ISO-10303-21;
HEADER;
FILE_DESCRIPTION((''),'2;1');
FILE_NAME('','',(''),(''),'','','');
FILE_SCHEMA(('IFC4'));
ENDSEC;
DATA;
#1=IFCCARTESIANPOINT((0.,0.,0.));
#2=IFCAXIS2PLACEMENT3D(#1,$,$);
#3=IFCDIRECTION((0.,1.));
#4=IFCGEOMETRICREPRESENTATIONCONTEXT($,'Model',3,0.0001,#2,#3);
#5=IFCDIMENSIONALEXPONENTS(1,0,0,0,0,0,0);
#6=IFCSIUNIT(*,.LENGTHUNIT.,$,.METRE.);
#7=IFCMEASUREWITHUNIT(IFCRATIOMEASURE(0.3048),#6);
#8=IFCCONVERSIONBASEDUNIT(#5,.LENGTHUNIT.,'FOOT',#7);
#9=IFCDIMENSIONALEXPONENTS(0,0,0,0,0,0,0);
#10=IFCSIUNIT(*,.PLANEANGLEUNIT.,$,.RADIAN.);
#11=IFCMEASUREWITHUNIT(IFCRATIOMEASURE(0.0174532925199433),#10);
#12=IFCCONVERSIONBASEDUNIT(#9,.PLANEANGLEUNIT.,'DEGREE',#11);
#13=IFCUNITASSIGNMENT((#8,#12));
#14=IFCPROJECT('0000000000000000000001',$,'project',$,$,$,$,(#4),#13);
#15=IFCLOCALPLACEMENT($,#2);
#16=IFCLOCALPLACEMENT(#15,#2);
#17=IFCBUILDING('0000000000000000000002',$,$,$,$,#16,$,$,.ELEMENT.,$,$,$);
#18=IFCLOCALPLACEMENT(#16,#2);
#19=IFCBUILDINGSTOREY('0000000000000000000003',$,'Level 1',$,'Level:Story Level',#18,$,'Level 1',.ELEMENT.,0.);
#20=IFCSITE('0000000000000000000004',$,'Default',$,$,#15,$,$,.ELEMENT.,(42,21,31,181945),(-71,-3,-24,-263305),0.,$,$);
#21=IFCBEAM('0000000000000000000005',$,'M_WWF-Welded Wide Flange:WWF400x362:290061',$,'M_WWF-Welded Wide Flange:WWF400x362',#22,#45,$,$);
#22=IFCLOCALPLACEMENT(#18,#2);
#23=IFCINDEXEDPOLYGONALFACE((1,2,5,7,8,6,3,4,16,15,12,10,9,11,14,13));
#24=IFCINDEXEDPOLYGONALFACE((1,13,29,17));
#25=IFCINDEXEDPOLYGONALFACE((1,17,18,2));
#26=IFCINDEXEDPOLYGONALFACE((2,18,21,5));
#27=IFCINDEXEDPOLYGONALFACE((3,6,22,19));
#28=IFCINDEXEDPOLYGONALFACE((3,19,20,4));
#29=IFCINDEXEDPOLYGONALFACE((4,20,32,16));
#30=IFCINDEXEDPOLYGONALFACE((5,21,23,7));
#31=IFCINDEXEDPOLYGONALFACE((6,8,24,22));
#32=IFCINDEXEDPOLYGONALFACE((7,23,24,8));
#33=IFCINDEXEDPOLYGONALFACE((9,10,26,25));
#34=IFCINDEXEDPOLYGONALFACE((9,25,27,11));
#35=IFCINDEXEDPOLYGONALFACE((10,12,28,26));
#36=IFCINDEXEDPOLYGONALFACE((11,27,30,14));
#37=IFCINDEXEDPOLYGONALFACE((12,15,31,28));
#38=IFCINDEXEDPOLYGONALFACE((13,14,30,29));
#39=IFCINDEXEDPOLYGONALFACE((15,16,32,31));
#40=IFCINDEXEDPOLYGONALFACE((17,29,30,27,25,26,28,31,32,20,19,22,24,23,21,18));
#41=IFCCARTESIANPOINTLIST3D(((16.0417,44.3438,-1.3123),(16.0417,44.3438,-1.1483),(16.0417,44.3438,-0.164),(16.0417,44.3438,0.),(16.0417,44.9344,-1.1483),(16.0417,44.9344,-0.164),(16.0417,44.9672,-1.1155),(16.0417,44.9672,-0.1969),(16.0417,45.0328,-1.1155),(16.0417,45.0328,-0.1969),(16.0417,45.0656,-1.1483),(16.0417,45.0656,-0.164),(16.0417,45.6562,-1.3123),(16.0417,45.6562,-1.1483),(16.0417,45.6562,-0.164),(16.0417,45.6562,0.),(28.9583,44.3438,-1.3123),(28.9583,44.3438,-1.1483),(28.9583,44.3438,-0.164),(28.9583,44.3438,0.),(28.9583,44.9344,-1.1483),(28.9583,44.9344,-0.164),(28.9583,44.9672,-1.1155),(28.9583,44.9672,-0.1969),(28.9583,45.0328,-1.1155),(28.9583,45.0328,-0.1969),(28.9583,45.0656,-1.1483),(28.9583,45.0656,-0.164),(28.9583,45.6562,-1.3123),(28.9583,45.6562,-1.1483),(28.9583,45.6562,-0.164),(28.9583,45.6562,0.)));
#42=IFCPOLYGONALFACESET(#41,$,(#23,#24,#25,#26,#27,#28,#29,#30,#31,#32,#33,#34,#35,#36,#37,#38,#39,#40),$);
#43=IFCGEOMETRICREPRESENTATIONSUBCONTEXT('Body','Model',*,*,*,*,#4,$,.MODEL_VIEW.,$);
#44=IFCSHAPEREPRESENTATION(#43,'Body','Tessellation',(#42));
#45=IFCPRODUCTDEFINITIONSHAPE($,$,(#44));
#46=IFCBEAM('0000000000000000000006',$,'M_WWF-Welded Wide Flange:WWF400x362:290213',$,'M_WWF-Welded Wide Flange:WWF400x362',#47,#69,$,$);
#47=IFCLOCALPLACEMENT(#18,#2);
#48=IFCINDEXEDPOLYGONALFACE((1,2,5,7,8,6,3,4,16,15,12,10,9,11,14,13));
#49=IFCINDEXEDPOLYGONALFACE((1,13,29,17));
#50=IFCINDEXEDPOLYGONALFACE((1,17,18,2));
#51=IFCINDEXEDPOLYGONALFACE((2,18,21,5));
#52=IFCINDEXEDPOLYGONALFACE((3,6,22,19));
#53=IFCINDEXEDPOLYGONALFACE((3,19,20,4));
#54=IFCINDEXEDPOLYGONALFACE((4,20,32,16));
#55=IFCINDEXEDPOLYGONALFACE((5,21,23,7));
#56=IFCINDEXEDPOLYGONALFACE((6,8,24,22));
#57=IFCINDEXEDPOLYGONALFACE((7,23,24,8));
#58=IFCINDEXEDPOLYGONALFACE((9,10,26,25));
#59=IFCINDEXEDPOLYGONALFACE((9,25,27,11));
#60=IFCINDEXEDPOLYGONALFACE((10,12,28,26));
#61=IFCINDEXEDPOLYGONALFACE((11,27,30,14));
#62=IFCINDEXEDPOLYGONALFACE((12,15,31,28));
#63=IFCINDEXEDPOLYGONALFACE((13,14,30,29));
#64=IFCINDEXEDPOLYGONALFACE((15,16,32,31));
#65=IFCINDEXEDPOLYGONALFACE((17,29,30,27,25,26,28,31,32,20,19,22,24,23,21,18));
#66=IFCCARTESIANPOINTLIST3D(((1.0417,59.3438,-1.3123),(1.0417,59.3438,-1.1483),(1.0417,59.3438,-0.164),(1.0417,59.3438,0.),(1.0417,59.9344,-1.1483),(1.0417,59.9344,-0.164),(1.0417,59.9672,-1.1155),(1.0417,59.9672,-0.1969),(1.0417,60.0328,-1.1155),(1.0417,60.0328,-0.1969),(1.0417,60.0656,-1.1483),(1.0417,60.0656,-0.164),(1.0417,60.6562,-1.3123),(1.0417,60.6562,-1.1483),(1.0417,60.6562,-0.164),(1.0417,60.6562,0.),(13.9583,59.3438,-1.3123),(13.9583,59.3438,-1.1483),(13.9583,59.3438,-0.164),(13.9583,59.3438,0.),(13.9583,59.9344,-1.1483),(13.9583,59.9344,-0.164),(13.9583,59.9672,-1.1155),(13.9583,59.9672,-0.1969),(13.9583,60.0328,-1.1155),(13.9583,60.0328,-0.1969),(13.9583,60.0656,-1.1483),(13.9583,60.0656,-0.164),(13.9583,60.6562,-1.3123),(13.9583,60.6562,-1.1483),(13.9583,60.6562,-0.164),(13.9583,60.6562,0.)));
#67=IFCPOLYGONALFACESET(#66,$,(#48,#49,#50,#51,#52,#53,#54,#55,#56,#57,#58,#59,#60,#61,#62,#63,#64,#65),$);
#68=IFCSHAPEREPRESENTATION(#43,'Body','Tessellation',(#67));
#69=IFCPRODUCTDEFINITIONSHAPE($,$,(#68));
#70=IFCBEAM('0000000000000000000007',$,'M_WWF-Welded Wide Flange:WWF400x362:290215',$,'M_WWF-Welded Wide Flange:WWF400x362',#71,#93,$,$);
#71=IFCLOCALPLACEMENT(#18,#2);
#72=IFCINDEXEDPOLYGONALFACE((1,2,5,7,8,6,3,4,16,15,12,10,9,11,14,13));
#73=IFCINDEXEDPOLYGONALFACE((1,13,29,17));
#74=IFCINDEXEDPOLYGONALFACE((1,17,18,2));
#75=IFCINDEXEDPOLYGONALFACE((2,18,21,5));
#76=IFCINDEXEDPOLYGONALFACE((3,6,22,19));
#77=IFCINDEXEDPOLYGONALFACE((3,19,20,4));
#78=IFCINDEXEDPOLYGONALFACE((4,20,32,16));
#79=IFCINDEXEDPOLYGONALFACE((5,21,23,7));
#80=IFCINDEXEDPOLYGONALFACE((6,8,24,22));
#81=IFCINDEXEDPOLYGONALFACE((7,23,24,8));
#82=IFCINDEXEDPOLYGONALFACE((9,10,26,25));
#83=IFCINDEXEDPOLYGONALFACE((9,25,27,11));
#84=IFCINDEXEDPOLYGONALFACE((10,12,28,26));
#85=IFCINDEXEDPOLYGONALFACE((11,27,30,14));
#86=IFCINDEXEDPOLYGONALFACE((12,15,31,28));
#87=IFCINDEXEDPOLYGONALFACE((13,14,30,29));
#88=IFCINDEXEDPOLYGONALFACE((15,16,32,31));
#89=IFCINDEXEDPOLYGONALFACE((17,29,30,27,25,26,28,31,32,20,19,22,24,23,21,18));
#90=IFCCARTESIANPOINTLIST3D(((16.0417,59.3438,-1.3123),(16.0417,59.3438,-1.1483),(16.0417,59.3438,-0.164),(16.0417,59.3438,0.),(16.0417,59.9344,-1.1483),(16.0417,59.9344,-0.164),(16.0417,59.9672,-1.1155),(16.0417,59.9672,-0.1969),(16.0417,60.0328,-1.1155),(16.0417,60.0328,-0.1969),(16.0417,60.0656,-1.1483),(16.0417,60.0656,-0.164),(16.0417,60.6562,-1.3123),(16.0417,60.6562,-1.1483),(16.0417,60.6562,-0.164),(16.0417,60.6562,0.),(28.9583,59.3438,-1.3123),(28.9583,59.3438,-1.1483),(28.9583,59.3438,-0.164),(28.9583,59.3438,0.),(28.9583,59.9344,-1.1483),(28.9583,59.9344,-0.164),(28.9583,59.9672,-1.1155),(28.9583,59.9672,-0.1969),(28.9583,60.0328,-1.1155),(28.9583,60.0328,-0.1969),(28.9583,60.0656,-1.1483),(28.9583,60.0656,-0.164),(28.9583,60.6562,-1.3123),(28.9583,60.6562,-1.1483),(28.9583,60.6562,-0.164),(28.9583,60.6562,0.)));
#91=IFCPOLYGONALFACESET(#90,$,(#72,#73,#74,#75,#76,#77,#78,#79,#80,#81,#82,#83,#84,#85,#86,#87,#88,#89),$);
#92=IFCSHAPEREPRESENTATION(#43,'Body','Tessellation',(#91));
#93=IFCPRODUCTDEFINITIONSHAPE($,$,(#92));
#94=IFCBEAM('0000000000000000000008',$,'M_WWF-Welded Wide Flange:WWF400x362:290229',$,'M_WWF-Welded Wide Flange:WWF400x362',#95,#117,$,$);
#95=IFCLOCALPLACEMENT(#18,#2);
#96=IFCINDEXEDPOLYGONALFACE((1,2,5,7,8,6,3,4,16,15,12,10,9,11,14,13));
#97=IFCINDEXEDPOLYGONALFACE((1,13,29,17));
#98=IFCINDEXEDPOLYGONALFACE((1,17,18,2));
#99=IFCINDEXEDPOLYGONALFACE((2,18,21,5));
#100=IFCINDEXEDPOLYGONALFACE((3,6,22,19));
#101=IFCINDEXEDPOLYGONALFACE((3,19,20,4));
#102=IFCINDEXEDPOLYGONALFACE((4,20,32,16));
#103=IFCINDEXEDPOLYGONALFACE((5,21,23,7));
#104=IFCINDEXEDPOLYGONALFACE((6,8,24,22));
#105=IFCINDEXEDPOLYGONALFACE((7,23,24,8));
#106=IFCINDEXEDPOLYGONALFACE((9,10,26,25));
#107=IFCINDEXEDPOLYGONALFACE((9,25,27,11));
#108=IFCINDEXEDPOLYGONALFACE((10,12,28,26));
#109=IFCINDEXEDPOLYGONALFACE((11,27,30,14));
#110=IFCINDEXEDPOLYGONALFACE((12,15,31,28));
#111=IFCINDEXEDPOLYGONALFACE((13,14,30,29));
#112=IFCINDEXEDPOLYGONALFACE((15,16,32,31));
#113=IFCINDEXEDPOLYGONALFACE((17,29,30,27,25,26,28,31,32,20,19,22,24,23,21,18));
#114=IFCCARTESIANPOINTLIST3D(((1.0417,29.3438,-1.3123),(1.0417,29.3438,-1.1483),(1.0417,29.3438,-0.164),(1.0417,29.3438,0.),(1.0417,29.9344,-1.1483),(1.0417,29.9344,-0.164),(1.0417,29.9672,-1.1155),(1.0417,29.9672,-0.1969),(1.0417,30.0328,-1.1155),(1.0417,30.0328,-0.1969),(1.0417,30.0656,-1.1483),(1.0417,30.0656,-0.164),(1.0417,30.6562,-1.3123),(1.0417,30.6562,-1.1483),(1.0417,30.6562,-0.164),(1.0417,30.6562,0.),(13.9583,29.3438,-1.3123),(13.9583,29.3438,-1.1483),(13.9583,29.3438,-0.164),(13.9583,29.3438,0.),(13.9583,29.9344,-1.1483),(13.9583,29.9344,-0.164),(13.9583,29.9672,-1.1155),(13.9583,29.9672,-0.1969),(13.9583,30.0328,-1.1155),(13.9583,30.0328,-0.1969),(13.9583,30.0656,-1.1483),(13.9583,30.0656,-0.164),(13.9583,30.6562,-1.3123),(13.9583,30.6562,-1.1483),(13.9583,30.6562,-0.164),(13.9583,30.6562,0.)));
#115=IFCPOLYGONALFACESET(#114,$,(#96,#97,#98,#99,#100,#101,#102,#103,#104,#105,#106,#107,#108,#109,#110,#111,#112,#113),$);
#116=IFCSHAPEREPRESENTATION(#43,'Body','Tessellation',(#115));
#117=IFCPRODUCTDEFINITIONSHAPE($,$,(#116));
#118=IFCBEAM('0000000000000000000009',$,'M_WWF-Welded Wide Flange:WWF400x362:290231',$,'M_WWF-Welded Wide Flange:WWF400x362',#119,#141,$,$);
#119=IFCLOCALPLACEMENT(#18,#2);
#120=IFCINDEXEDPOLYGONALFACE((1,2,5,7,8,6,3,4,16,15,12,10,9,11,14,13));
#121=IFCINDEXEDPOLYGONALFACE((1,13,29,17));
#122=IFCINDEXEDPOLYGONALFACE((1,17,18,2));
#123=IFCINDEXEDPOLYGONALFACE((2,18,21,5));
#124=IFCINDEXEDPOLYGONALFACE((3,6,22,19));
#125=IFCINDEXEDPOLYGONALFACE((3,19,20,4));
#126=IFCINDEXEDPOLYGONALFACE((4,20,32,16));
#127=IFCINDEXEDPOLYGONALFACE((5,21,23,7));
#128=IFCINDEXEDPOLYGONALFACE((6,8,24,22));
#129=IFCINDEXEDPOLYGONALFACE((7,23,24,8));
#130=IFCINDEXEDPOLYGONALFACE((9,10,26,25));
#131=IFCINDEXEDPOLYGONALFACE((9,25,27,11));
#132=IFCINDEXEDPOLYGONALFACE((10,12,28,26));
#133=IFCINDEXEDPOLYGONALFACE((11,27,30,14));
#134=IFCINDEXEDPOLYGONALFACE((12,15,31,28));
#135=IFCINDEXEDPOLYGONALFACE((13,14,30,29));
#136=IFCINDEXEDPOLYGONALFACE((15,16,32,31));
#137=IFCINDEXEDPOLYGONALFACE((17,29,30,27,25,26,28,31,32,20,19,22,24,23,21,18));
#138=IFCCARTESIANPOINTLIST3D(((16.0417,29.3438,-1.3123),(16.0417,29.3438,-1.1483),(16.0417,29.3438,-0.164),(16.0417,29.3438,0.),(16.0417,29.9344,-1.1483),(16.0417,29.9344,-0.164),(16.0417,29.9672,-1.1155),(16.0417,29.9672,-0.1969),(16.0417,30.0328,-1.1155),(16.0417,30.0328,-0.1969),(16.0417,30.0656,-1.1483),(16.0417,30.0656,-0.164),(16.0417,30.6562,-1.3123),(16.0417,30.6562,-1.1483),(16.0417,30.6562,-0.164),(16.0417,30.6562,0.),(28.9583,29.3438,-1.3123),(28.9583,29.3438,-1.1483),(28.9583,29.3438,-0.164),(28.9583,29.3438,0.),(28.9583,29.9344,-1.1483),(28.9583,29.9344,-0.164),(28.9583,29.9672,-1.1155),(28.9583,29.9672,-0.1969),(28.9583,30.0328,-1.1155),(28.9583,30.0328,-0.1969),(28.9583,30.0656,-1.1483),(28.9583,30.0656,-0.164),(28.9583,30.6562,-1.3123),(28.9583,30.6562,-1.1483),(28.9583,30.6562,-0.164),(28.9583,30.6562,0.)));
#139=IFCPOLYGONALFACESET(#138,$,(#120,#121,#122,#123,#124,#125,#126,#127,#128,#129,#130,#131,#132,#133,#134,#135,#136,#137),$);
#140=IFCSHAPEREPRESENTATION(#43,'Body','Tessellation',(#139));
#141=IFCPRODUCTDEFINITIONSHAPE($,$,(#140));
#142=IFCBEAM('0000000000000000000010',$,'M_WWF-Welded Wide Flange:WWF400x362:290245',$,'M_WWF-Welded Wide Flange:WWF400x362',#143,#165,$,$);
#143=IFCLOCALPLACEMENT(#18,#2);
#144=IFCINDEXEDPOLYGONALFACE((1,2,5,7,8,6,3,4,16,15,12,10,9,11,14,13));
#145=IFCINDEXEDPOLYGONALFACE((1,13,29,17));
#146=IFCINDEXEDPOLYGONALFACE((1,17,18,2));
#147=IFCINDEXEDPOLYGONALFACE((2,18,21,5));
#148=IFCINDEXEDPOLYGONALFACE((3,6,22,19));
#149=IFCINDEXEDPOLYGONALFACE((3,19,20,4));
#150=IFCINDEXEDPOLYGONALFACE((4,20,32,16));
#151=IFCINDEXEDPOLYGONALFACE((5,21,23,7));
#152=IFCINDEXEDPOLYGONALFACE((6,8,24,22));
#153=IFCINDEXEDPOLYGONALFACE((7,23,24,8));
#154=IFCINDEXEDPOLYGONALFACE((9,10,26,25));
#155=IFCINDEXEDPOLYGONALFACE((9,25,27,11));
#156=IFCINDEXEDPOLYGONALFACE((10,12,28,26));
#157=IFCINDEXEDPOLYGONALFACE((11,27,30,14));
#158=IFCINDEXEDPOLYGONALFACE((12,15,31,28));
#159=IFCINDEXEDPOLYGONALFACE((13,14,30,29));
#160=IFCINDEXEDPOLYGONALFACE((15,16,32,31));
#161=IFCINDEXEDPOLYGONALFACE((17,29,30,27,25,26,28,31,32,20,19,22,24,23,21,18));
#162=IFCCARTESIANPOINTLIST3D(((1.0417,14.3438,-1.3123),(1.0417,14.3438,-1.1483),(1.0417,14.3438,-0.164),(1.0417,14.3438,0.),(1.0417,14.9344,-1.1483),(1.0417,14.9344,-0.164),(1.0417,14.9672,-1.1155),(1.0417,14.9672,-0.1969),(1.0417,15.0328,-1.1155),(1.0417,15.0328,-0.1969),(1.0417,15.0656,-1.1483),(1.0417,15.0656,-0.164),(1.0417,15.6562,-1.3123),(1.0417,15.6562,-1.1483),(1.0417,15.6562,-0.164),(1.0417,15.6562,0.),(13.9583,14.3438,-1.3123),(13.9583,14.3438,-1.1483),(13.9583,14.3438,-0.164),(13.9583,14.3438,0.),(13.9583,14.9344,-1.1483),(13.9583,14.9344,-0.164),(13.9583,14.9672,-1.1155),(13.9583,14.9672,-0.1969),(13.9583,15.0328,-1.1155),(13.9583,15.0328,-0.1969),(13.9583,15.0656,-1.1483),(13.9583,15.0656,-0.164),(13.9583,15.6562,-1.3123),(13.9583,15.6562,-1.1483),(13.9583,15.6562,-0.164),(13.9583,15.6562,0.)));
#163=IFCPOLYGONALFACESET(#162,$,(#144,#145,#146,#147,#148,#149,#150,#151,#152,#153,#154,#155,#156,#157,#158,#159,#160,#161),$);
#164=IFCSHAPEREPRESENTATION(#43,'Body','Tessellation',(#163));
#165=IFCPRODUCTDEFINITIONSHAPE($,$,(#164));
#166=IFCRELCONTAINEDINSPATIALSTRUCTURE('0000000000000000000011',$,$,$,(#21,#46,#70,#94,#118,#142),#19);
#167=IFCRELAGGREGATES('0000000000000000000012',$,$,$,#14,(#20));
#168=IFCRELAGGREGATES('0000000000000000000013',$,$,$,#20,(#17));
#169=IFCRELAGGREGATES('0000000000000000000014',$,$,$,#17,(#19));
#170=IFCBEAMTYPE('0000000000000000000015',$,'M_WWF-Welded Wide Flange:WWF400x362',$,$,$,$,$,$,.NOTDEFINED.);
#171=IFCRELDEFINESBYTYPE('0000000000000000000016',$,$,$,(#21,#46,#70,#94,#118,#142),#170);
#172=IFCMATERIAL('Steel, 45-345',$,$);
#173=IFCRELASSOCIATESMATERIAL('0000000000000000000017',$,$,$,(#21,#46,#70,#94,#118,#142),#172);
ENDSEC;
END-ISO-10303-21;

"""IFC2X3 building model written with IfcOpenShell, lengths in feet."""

from ifc_helpers import new_model, entity, si_unit, converted_unit, direction, frame, origin, place, context, subcontext, project, spatial, polyline, outline, extrude, material, type_object, element, save


model = new_model("IFC2X3")

# Units and contexts
model_context = context("Model", 3, precision=0.0001, world=origin(), true_north=direction((0.0, 1.0)))
body_context = subcontext(model_context, "Body", "Model", "MODEL_VIEW")
ifc_project = project(units=[converted_unit("LENGTHUNIT", "FOOT", entity("IfcRatioMeasure", 0.3048), si_unit("LENGTHUNIT", "METRE"), dimensions=[1, 0, 0, 0, 0, 0, 0]), converted_unit("PLANEANGLEUNIT", "DEGREE", entity("IfcRatioMeasure", 0.0174532925199433), si_unit("PLANEANGLEUNIT", "RADIAN"), dimensions=[0, 0, 0, 0, 0, 0, 0])], contexts=[model_context])

# Site, building, storey
site_placement = place(None, origin())
site = spatial("IfcSite", under=ifc_project, at=site_placement, Name="Default", CompositionType="ELEMENT", RefLatitude=(42, 21, 31, 181945), RefLongitude=(-71, -3, -24, -263305), RefElevation=0.0)
building_placement = place(site_placement, origin())
building = spatial("IfcBuilding", under=site, at=building_placement, CompositionType="ELEMENT")
storey_placement = place(building_placement, origin())
storey = spatial("IfcBuildingStorey", under=building, at=storey_placement, Name="Level 1", ObjectType="Level:Story Level", LongName="Level 1", CompositionType="ELEMENT", Elevation=0.0)

# Shared definitions
ifc_material = material(Name="Steel, 45-345")

# Beams
beam_type = type_object("IfcBeamType", Name="M_WWF-Welded Wide Flange:WWF400x362", PredefinedType="NOTDEFINED")
beam_1_placement = place(storey_placement, frame((15.0, 45.0, 0.0)))
element("IfcBeam", 1, at=beam_1_placement, inside=storey, type_object=beam_type, material=ifc_material, Name="M_WWF-Welded Wide Flange:WWF400x362:290061", ObjectType="M_WWF-Welded Wide Flange:WWF400x362", context=body_context, shape_type="SweptSolid", body=[
    extrude(outline(polyline([(-0.6562, -0.6562), (-0.4921, -0.6562), (-0.4921, -0.0656), (-0.4593, -0.0328), (0.4593, -0.0328), (0.4921, -0.0656), (0.4921, -0.6562), (0.6562, -0.6562), (0.6562, 0.6562), (0.4921, 0.6562), (0.4921, 0.0656), (0.4593, 0.0328), (-0.4593, 0.0328), (-0.4921, 0.0656), (-0.4921, 0.6562), (-0.6562, 0.6562), (-0.6562, -0.6562)])), frame((1.0417, 0.0, -0.6562), z_axis=(1.0, 0.0, 0.0), x_axis=(0.0, 0.0, -1.0)), (0.0, 0.0, 1.0), 12.9167),
])
beam_2_placement = place(storey_placement, frame((0.0, 60.0, 0.0)))
element("IfcBeam", 2, at=beam_2_placement, inside=storey, type_object=beam_type, material=ifc_material, Name="M_WWF-Welded Wide Flange:WWF400x362:290213", ObjectType="M_WWF-Welded Wide Flange:WWF400x362", context=body_context, shape_type="SweptSolid", body=[
    extrude(outline(polyline([(-0.6562, -0.6562), (-0.4921, -0.6562), (-0.4921, -0.0656), (-0.4593, -0.0328), (0.4593, -0.0328), (0.4921, -0.0656), (0.4921, -0.6562), (0.6562, -0.6562), (0.6562, 0.6562), (0.4921, 0.6562), (0.4921, 0.0656), (0.4593, 0.0328), (-0.4593, 0.0328), (-0.4921, 0.0656), (-0.4921, 0.6562), (-0.6562, 0.6562), (-0.6562, -0.6562)])), frame((1.0417, 0.0, -0.6562), z_axis=(1.0, 0.0, 0.0), x_axis=(0.0, 0.0, -1.0)), (0.0, 0.0, 1.0), 12.9167),
])
beam_3_placement = place(storey_placement, frame((15.0, 60.0, 0.0)))
element("IfcBeam", 3, at=beam_3_placement, inside=storey, type_object=beam_type, material=ifc_material, Name="M_WWF-Welded Wide Flange:WWF400x362:290215", ObjectType="M_WWF-Welded Wide Flange:WWF400x362", context=body_context, shape_type="SweptSolid", body=[
    extrude(outline(polyline([(-0.6562, -0.6562), (-0.4921, -0.6562), (-0.4921, -0.0656), (-0.4593, -0.0328), (0.4593, -0.0328), (0.4921, -0.0656), (0.4921, -0.6562), (0.6562, -0.6562), (0.6562, 0.6562), (0.4921, 0.6562), (0.4921, 0.0656), (0.4593, 0.0328), (-0.4593, 0.0328), (-0.4921, 0.0656), (-0.4921, 0.6562), (-0.6562, 0.6562), (-0.6562, -0.6562)])), frame((1.0417, 0.0, -0.6562), z_axis=(1.0, 0.0, 0.0), x_axis=(0.0, 0.0, -1.0)), (0.0, 0.0, 1.0), 12.9167),
])
beam_4_placement = place(storey_placement, frame((0.0, 30.0, 0.0)))
element("IfcBeam", 4, at=beam_4_placement, inside=storey, type_object=beam_type, material=ifc_material, Name="M_WWF-Welded Wide Flange:WWF400x362:290229", ObjectType="M_WWF-Welded Wide Flange:WWF400x362", context=body_context, shape_type="SweptSolid", body=[
    extrude(outline(polyline([(-0.6562, -0.6562), (-0.4921, -0.6562), (-0.4921, -0.0656), (-0.4593, -0.0328), (0.4593, -0.0328), (0.4921, -0.0656), (0.4921, -0.6562), (0.6562, -0.6562), (0.6562, 0.6562), (0.4921, 0.6562), (0.4921, 0.0656), (0.4593, 0.0328), (-0.4593, 0.0328), (-0.4921, 0.0656), (-0.4921, 0.6562), (-0.6562, 0.6562), (-0.6562, -0.6562)])), frame((1.0417, 0.0, -0.6562), z_axis=(1.0, 0.0, 0.0), x_axis=(0.0, 0.0, -1.0)), (0.0, 0.0, 1.0), 12.9167),
])
beam_5_placement = place(storey_placement, frame((15.0, 30.0, 0.0)))
element("IfcBeam", 5, at=beam_5_placement, inside=storey, type_object=beam_type, material=ifc_material, Name="M_WWF-Welded Wide Flange:WWF400x362:290231", ObjectType="M_WWF-Welded Wide Flange:WWF400x362", context=body_context, shape_type="SweptSolid", body=[
    extrude(outline(polyline([(-0.6562, -0.6562), (-0.4921, -0.6562), (-0.4921, -0.0656), (-0.4593, -0.0328), (0.4593, -0.0328), (0.4921, -0.0656), (0.4921, -0.6562), (0.6562, -0.6562), (0.6562, 0.6562), (0.4921, 0.6562), (0.4921, 0.0656), (0.4593, 0.0328), (-0.4593, 0.0328), (-0.4921, 0.0656), (-0.4921, 0.6562), (-0.6562, 0.6562), (-0.6562, -0.6562)])), frame((1.0417, 0.0, -0.6562), z_axis=(1.0, 0.0, 0.0), x_axis=(0.0, 0.0, -1.0)), (0.0, 0.0, 1.0), 12.9167),
])
beam_6_placement = place(storey_placement, frame((0.0, 15.0, 0.0)))
element("IfcBeam", 6, at=beam_6_placement, inside=storey, type_object=beam_type, material=ifc_material, Name="M_WWF-Welded Wide Flange:WWF400x362:290245", ObjectType="M_WWF-Welded Wide Flange:WWF400x362", context=body_context, shape_type="SweptSolid", body=[
    extrude(outline(polyline([(-0.6562, -0.6562), (-0.4921, -0.6562), (-0.4921, -0.0656), (-0.4593, -0.0328), (0.4593, -0.0328), (0.4921, -0.0656), (0.4921, -0.6562), (0.6562, -0.6562), (0.6562, 0.6562), (0.4921, 0.6562), (0.4921, 0.0656), (0.4593, 0.0328), (-0.4593, 0.0328), (-0.4921, 0.0656), (-0.4921, 0.6562), (-0.6562, 0.6562), (-0.6562, -0.6562)])), frame((1.0417, 0.0, -0.6562), z_axis=(1.0, 0.0, 0.0), x_axis=(0.0, 0.0, -1.0)), (0.0, 0.0, 1.0), 12.9167),
])

save(model, "model.ifc")
